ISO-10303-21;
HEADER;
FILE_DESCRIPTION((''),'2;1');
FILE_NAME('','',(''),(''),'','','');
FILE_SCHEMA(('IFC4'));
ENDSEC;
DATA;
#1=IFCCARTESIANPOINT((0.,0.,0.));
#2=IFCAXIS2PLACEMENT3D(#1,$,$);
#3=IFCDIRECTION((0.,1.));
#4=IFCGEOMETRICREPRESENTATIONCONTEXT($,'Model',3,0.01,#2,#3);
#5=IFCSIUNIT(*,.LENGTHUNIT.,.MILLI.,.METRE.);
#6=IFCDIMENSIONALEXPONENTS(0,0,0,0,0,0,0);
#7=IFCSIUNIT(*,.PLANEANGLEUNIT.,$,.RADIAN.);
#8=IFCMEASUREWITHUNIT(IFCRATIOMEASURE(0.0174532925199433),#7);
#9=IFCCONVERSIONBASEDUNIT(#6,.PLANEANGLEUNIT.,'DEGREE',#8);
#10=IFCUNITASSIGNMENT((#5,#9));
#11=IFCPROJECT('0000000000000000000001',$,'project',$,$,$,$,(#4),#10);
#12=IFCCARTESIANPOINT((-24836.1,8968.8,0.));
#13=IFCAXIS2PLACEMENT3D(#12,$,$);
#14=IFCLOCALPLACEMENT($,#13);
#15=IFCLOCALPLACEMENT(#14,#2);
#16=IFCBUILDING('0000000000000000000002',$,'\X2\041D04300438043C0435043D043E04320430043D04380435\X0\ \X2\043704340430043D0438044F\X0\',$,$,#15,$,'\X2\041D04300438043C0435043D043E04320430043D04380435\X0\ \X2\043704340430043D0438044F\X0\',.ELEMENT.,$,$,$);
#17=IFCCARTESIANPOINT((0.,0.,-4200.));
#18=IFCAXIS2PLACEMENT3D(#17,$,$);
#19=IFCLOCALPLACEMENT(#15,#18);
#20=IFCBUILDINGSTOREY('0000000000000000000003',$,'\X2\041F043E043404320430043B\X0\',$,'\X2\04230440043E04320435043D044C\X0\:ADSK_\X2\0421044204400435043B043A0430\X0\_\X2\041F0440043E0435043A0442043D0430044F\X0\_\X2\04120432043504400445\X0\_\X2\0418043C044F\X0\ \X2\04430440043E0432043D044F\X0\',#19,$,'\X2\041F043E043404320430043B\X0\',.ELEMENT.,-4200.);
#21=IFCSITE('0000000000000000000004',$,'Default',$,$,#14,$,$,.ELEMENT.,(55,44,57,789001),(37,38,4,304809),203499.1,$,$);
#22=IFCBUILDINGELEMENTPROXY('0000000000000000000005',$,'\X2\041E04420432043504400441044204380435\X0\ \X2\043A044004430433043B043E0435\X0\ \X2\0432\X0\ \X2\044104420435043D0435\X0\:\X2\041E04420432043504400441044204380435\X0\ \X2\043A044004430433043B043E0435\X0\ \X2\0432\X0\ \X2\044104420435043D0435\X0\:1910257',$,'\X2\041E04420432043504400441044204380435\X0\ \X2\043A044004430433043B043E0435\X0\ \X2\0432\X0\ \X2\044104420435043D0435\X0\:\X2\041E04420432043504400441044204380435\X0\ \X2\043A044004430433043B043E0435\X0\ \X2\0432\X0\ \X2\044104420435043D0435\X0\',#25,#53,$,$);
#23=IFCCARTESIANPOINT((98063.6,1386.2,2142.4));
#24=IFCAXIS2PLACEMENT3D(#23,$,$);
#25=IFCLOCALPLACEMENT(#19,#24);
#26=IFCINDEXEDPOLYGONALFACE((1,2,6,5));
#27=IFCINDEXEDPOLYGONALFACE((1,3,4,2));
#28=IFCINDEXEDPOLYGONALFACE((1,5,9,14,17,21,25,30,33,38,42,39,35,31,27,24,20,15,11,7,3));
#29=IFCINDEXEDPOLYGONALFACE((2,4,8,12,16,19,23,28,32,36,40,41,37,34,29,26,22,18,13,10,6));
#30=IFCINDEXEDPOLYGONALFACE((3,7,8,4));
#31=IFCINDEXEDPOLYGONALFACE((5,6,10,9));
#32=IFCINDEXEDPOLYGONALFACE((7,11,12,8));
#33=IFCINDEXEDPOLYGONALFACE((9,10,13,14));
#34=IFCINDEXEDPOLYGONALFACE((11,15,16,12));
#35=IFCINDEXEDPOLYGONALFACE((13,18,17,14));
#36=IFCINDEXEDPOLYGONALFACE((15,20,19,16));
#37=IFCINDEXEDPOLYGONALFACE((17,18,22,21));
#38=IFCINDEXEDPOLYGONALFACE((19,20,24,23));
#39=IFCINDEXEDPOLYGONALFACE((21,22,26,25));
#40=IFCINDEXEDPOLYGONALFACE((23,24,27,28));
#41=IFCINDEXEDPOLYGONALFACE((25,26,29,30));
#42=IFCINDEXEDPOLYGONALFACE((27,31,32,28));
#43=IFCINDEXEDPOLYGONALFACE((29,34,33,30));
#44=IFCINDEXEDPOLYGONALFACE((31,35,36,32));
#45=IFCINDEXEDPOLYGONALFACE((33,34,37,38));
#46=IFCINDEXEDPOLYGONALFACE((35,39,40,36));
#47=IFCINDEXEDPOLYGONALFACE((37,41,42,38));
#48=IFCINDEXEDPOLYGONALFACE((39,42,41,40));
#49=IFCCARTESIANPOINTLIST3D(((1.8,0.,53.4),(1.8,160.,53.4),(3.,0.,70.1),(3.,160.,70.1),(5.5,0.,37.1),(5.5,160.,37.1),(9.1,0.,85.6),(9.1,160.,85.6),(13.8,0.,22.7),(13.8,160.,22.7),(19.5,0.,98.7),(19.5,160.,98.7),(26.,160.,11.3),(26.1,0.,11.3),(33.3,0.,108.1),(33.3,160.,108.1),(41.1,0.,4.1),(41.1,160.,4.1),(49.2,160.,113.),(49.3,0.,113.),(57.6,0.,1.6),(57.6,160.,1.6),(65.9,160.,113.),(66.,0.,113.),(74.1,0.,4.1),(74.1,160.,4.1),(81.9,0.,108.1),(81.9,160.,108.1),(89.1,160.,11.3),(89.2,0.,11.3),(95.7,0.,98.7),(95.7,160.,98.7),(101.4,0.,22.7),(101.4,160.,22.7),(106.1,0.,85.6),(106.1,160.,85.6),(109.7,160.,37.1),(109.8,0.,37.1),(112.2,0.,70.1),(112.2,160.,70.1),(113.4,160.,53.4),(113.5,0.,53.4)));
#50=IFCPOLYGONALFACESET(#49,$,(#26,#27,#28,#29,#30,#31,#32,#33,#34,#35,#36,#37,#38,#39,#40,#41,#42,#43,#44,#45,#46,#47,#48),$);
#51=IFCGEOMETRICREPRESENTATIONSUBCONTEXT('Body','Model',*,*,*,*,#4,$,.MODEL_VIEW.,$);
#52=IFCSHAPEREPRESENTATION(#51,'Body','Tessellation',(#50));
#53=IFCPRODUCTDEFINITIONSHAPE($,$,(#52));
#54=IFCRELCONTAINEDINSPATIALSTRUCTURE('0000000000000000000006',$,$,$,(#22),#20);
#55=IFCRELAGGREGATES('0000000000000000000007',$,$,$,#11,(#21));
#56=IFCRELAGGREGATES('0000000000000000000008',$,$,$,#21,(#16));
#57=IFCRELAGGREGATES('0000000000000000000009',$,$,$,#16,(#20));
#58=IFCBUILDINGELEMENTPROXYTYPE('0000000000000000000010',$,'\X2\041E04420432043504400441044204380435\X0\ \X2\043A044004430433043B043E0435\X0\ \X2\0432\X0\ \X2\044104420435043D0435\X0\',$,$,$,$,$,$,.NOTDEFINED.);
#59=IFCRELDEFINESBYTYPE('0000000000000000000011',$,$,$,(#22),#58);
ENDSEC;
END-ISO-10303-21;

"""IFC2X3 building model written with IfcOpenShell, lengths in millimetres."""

from ifc_helpers import new_model, entity, si_unit, converted_unit, direction, frame, origin, origin_2d_with_axis, place, context, subcontext, project, spatial, circle, extrude, type_object, element, save


model = new_model("IFC2X3")

# Units and contexts
model_context = context("Model", 3, precision=0.01, world=origin(), true_north=direction((0.0, 1.0)))
body_context = subcontext(model_context, "Body", "Model", "MODEL_VIEW")
ifc_project = project(units=[si_unit("LENGTHUNIT", "METRE", prefix="MILLI"), converted_unit("PLANEANGLEUNIT", "DEGREE", entity("IfcRatioMeasure", 0.0174532925199433), si_unit("PLANEANGLEUNIT", "RADIAN"), dimensions=[0, 0, 0, 0, 0, 0, 0])], contexts=[model_context])

# Site, building, storey
site_placement = place(None, frame((-24836.1, 8968.8, 0.0)))
site = spatial("IfcSite", under=ifc_project, at=site_placement, Name="Default", CompositionType="ELEMENT", RefLatitude=(55, 44, 57, 789001), RefLongitude=(37, 38, 4, 304809), RefElevation=203499.1)
building_placement = place(site_placement, origin())
building = spatial("IfcBuilding", under=site, at=building_placement, Name="Наименование здания", LongName="Наименование здания", CompositionType="ELEMENT")
storey_placement = place(building_placement, frame((0.0, 0.0, -4200.0)))
storey = spatial("IfcBuildingStorey", under=building, at=storey_placement, Name="Подвал", ObjectType="Уровень:ADSK_Стрелка_Проектная_Вверх_Имя уровня", LongName="Подвал", CompositionType="ELEMENT", Elevation=-4200.0)

# Building element proxy
building_element_proxy_type_1 = type_object("IfcBuildingElementProxyType", Name="Отверстие круглое в стене", PredefinedType="NOTDEFINED")
proxy_1_placement = place(storey_placement, frame((98063.6, 1386.2, 2142.4)))
element("IfcBuildingElementProxy", 1, at=proxy_1_placement, inside=storey, type_object=building_element_proxy_type_1, Name="Отверстие круглое в стене:Отверстие круглое в стене:1910257", ObjectType="Отверстие круглое в стене:Отверстие круглое в стене", context=body_context, shape_type="SweptSolid", body=[
    extrude(circle(Radius=56.0, at=origin_2d_with_axis()), frame((57.6, 0.0, 57.6), z_axis=(-0.000218, 1.0, 0.0), x_axis=(0.0, 0.0, -1.0)), (0.0, 0.0, 1.0), 160.0),
])

save(model, "model.ifc")
